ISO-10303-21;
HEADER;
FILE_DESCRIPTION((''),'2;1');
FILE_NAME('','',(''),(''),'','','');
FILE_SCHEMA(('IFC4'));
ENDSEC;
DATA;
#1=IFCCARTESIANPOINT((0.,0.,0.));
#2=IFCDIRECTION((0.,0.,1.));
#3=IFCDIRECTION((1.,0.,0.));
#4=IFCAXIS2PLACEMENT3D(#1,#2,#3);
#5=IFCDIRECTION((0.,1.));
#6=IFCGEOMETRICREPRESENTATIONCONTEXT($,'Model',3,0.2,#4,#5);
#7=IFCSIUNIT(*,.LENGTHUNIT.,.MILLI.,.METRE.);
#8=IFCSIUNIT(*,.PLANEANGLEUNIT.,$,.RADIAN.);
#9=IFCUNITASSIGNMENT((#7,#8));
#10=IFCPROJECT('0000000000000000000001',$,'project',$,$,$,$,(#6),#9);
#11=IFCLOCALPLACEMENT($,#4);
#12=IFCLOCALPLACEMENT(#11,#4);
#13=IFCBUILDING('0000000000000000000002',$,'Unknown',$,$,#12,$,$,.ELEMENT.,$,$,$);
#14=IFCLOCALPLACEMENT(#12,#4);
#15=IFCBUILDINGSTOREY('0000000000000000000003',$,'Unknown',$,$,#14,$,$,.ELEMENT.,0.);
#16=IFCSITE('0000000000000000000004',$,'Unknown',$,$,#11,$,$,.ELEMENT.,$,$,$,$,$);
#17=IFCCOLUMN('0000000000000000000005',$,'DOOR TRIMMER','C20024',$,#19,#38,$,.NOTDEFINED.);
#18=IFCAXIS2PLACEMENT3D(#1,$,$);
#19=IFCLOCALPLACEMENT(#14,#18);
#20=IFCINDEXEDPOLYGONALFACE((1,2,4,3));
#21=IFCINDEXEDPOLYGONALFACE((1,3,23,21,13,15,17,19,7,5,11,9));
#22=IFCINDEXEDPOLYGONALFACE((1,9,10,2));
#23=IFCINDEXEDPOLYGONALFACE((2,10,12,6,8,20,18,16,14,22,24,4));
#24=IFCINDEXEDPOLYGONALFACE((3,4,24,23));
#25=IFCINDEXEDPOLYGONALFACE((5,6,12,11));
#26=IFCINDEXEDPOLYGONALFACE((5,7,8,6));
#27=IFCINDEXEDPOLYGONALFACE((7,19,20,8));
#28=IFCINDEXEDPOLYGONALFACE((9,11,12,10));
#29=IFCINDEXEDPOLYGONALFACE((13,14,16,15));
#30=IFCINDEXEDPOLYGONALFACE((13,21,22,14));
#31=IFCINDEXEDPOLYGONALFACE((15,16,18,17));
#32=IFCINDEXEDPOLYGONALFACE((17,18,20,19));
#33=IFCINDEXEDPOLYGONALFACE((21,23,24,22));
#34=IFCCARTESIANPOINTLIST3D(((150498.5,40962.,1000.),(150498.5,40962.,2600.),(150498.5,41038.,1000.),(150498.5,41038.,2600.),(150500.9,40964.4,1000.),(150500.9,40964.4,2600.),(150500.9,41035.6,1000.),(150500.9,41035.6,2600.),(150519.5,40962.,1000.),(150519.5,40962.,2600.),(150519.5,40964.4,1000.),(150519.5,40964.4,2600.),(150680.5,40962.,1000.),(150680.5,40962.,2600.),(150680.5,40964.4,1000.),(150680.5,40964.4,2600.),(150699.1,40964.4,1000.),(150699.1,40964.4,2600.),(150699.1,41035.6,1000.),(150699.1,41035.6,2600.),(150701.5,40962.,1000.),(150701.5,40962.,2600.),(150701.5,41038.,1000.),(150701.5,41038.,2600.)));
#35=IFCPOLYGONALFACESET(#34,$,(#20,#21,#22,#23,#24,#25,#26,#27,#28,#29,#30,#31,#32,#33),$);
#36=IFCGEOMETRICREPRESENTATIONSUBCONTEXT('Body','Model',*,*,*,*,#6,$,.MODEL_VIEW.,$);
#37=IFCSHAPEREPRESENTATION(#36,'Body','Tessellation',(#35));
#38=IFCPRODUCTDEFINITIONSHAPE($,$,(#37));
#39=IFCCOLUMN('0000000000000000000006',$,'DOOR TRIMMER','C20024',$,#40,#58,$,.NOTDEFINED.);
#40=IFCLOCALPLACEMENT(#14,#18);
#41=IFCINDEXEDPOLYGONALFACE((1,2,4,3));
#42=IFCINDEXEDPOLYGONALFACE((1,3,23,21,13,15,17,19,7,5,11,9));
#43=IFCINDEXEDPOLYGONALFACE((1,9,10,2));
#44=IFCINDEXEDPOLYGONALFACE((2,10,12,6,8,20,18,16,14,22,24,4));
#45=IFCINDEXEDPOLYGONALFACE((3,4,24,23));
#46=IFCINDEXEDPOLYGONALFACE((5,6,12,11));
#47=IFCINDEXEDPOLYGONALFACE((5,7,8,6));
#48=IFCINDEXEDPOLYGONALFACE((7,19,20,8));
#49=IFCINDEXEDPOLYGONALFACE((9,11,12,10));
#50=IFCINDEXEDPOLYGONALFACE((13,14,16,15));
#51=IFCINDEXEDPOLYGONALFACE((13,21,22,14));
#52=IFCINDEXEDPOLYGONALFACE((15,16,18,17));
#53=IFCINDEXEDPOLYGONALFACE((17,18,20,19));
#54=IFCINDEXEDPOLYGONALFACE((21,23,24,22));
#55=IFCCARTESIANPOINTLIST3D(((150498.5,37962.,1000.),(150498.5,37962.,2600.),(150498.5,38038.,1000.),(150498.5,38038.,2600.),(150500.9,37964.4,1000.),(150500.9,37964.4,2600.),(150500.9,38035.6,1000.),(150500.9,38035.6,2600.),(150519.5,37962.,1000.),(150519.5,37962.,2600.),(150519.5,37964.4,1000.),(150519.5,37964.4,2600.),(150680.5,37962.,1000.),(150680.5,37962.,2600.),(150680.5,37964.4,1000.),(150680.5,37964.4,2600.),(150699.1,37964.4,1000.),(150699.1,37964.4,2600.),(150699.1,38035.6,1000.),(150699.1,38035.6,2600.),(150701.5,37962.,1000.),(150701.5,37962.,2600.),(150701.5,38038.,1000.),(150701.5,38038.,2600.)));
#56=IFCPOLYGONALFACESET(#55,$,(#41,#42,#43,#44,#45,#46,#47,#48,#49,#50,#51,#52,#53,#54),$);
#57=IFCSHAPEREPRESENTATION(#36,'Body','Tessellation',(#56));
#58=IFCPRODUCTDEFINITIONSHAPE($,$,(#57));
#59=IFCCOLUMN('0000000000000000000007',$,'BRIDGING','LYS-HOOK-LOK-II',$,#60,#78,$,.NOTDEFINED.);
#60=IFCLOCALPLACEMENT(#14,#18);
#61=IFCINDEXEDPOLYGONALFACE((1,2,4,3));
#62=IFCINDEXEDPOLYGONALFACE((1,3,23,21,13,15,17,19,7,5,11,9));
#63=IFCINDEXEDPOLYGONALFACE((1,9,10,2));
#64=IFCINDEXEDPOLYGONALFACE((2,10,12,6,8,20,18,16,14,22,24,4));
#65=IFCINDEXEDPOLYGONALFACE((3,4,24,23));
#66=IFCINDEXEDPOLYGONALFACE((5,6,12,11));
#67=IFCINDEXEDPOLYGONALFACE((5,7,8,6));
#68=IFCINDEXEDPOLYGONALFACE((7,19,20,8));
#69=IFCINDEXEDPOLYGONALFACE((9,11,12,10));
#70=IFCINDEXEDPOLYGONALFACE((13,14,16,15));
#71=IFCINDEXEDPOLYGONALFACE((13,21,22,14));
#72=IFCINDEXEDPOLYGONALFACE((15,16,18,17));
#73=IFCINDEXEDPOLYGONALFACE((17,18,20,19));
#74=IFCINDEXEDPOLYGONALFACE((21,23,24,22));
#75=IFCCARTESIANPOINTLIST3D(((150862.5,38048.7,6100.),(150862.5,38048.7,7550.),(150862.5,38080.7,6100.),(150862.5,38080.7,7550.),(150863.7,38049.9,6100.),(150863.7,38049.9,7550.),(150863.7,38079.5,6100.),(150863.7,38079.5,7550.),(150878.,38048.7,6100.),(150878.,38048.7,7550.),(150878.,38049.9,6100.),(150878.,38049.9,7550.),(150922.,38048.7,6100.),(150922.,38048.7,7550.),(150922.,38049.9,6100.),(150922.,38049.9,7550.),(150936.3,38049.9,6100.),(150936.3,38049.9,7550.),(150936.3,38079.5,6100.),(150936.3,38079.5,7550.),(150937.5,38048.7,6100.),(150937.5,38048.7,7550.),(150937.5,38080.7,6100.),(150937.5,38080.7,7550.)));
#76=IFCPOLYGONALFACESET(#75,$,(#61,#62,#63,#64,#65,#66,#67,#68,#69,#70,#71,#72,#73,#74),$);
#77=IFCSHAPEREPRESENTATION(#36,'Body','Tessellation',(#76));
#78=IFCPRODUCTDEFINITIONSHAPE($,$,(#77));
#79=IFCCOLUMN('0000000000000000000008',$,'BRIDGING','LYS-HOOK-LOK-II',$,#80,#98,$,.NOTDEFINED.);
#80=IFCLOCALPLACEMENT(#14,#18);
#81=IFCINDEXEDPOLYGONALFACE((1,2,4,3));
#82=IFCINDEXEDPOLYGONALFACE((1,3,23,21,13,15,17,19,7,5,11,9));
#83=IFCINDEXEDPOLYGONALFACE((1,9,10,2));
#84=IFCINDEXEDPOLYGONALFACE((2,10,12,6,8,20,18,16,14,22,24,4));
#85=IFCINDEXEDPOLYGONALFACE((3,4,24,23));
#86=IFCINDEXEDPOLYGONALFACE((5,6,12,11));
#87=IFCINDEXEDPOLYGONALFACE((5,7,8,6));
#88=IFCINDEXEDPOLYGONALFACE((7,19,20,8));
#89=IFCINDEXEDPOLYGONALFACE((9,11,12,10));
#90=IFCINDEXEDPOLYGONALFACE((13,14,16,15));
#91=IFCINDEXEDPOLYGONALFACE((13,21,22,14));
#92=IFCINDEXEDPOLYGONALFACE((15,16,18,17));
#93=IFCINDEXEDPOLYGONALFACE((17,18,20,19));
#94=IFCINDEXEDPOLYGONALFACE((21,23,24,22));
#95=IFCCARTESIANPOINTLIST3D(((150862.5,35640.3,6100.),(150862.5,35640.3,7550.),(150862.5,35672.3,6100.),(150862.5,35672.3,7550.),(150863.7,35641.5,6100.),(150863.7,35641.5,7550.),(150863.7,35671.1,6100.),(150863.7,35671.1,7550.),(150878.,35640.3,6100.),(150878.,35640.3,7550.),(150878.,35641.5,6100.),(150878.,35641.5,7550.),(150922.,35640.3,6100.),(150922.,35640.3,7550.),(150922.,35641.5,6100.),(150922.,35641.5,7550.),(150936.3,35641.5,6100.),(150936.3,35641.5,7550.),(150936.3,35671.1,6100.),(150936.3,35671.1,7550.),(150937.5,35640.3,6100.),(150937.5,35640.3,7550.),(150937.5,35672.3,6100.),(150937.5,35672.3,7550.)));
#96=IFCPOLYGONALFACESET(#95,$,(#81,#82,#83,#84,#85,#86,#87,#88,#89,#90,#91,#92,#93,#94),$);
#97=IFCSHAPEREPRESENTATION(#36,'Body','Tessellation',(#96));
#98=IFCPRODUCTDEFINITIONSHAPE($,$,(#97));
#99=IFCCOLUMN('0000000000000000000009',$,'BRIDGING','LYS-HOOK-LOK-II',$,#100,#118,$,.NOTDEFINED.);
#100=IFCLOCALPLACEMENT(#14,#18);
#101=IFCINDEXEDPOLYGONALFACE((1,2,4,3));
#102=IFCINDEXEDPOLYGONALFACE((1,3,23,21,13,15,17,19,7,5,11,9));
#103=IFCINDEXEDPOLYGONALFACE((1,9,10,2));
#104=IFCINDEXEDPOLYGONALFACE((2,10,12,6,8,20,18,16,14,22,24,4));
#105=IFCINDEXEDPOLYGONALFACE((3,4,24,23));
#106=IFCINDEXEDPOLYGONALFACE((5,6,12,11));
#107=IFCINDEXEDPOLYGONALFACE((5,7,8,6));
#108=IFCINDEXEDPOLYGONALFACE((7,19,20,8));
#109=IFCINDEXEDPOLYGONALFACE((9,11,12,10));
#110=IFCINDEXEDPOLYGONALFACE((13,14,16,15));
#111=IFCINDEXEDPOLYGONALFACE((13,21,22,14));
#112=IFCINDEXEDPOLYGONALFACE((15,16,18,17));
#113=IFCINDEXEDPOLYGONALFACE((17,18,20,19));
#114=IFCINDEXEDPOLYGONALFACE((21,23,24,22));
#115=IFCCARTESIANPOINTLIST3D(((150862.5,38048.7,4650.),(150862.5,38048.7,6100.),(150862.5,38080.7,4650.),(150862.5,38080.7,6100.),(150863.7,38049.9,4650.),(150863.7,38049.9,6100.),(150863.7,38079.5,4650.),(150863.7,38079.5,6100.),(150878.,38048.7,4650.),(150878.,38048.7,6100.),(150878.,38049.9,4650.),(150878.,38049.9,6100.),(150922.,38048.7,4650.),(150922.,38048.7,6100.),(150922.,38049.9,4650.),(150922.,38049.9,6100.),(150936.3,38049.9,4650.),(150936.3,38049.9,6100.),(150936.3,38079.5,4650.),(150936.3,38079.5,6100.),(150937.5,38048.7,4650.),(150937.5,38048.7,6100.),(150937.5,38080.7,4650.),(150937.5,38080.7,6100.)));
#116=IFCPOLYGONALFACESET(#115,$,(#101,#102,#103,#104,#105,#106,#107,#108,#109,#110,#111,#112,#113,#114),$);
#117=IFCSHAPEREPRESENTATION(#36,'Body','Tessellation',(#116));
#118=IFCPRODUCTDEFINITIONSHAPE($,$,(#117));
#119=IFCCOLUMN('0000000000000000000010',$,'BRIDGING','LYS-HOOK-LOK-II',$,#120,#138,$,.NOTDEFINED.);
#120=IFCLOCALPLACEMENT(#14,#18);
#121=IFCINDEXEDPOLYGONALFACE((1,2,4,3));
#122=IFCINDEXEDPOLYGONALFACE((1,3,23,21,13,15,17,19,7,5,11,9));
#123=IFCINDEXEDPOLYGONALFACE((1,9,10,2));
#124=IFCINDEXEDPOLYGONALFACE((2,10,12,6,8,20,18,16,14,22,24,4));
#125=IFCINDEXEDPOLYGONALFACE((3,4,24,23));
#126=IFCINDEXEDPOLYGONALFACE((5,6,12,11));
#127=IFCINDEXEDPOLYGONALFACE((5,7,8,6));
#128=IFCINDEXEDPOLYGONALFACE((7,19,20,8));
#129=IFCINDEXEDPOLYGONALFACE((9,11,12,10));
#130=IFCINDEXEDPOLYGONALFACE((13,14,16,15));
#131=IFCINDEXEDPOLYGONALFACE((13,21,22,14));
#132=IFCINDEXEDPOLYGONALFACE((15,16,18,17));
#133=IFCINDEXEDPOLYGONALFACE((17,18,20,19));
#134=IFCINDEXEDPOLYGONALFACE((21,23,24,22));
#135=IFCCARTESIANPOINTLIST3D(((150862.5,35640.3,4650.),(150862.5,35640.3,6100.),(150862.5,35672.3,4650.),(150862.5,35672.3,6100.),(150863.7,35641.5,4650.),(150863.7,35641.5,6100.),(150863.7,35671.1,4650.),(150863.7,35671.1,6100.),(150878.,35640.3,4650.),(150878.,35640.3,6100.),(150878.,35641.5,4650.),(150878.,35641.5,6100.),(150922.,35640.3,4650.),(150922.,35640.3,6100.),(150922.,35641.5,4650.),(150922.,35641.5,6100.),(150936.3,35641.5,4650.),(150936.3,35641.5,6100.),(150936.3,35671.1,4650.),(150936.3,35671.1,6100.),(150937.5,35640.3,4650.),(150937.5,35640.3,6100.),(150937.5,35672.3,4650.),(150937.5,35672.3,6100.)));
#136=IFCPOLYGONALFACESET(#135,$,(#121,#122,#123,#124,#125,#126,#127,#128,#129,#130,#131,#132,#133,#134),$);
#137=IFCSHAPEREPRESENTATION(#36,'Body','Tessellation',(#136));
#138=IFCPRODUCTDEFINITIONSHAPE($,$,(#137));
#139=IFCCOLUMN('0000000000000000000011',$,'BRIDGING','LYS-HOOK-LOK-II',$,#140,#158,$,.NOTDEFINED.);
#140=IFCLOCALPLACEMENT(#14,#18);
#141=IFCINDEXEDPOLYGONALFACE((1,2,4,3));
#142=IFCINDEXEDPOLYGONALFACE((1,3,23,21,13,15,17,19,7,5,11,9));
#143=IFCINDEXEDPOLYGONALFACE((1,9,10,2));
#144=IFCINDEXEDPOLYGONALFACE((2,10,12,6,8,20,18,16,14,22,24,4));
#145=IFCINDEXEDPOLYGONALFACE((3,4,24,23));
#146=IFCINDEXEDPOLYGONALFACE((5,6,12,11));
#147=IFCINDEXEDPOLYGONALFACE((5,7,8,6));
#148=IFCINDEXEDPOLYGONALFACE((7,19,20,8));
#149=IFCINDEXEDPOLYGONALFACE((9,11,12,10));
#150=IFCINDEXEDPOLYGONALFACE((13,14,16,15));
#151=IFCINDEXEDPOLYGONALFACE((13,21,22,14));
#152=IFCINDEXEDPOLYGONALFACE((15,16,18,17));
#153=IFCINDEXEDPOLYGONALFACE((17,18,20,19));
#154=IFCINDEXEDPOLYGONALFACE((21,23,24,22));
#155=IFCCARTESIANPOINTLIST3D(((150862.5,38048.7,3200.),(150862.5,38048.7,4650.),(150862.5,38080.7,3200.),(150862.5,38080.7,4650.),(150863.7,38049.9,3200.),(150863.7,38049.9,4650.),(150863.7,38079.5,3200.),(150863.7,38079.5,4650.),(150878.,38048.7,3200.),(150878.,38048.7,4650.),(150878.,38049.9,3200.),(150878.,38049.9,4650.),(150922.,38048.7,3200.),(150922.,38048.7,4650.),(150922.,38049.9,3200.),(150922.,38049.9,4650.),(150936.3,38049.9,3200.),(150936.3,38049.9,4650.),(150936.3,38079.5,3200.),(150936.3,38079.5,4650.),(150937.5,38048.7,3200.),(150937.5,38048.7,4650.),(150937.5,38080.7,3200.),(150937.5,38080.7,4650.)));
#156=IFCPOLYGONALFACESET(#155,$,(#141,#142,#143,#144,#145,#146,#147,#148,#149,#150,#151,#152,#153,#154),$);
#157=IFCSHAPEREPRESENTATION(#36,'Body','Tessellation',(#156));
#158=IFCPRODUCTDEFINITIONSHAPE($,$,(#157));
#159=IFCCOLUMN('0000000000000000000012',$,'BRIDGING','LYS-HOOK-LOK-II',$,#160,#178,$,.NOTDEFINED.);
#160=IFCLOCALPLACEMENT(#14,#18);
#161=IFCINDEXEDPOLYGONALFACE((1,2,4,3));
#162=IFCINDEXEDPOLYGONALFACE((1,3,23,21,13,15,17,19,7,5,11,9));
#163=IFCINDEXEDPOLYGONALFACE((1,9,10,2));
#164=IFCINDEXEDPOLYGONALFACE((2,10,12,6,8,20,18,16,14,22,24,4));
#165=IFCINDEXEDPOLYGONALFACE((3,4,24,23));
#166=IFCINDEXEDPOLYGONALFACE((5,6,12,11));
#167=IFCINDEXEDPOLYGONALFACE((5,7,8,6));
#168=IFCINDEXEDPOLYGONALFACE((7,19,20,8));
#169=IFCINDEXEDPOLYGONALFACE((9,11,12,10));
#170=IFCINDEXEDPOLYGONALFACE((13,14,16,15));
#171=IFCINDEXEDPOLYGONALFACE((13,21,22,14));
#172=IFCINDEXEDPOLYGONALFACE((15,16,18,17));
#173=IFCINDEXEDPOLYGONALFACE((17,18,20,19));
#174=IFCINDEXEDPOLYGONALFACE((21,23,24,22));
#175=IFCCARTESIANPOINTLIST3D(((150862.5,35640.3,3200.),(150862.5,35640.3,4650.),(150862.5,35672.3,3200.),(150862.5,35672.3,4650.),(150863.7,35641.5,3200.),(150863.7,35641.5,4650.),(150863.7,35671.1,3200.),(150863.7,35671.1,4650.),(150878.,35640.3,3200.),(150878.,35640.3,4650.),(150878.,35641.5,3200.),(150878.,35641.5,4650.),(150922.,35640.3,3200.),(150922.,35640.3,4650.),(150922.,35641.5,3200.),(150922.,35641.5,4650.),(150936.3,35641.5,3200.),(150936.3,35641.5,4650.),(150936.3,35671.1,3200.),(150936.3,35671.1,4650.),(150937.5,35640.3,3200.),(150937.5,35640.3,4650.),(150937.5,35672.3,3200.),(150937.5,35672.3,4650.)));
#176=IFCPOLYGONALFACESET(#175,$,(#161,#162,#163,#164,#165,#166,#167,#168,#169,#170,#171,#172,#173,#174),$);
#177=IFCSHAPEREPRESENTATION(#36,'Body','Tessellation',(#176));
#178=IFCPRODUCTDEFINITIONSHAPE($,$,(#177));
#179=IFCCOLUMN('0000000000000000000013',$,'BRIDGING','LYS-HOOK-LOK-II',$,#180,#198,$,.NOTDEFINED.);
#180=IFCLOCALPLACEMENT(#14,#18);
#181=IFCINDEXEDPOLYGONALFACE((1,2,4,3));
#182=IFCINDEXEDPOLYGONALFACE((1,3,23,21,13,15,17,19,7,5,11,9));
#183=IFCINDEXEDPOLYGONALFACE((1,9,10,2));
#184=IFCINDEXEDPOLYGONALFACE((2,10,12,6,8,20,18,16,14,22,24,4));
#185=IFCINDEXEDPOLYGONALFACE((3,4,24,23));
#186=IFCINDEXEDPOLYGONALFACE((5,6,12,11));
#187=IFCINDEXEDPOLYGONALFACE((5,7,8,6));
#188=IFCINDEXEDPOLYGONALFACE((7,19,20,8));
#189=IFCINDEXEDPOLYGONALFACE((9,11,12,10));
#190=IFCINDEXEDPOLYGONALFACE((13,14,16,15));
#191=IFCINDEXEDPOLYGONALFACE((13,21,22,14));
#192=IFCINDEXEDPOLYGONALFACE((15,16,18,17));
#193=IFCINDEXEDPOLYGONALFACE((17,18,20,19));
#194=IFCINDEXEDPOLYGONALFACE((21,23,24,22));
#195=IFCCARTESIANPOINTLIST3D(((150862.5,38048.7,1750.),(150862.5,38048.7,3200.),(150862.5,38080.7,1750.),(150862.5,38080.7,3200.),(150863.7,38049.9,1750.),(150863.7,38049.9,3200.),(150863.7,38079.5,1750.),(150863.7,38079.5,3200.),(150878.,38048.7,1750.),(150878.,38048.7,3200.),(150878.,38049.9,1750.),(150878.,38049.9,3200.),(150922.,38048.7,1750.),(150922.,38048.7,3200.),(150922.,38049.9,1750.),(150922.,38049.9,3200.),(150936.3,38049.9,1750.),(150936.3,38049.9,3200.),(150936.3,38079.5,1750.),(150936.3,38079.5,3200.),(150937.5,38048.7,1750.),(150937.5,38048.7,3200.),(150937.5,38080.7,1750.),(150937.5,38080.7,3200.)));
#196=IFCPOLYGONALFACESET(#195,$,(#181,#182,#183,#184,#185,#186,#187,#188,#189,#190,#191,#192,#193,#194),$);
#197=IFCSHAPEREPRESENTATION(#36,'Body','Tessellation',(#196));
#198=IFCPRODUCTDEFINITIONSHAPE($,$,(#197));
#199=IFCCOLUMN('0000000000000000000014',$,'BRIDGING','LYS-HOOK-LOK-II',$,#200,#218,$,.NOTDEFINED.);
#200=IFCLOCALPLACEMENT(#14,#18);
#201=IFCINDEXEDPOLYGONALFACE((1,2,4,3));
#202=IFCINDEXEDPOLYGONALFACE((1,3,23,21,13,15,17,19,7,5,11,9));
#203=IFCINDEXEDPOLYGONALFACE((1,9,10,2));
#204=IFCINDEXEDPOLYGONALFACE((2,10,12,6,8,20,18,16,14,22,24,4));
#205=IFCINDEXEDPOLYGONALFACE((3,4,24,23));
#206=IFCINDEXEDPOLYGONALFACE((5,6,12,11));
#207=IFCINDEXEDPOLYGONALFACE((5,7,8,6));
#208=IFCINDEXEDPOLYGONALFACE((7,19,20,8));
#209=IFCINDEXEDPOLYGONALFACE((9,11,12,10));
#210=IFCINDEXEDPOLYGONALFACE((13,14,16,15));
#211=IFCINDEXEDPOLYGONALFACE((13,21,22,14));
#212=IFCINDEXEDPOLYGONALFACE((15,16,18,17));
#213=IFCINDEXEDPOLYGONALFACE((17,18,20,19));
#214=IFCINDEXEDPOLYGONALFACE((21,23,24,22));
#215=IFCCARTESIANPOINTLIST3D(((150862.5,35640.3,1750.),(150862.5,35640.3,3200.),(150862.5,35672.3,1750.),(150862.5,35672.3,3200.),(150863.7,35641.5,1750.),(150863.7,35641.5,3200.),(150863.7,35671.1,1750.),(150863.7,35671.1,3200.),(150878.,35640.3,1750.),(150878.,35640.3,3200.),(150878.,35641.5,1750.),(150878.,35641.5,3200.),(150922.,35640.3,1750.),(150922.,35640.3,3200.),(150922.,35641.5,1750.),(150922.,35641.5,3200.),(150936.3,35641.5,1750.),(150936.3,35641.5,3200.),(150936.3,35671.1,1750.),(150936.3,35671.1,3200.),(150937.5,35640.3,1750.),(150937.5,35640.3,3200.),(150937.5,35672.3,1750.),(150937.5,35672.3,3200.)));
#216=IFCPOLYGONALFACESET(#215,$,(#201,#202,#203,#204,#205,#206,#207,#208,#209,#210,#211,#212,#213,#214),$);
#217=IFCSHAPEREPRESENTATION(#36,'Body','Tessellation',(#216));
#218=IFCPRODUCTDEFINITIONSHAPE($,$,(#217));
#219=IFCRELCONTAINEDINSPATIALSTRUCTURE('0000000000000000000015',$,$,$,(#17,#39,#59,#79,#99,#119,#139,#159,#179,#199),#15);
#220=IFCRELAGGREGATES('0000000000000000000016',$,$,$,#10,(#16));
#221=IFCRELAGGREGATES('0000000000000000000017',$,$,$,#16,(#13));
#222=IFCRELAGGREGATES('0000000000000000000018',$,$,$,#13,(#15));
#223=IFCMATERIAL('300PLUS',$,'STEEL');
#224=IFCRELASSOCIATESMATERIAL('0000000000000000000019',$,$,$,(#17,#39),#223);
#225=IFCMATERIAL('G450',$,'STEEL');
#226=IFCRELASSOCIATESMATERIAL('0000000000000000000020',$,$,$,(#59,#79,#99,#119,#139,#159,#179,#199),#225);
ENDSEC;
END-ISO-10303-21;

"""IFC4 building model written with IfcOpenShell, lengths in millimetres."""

from ifc_helpers import new_model, si_unit, direction, frame, origin_with_axes, place, context, subcontext, project, spatial, line, indexed_curve, outline, extrude, material, element, save


model = new_model("IFC4")

# Units and contexts
model_context = context("Model", 3, precision=0.2, world=origin_with_axes(), true_north=direction((0.0, 1.0)))
body_context = subcontext(model_context, "Body", "Model", "MODEL_VIEW")
ifc_project = project(units=[si_unit("LENGTHUNIT", "METRE", prefix="MILLI"), si_unit("PLANEANGLEUNIT", "RADIAN")], contexts=[model_context])

# Site, building, storey
site_placement = place(None, origin_with_axes())
site = spatial("IfcSite", under=ifc_project, at=site_placement, Name="Unknown", CompositionType="ELEMENT")
building_placement = place(site_placement, origin_with_axes())
building = spatial("IfcBuilding", under=site, at=building_placement, Name="Unknown", CompositionType="ELEMENT")
storey_placement = place(building_placement, origin_with_axes())
storey = spatial("IfcBuildingStorey", under=building, at=storey_placement, Name="Unknown", CompositionType="ELEMENT", Elevation=0.0)

# Columns
ifc_material_1 = material(Name="300PLUS", Category="STEEL")
for number, where, z_axis, x_axis, name in (
    (1, (150600.0, 41000.0, 1000.0), (0.0, -1.0, 0.0), (0.0, 0.0, 1.0), "DOOR TRIMMER"),
    (2, (150600.0, 38000.0, 1000.0), (0.0, -1.0, 0.0), (0.0, 0.0, 1.0), "DOOR TRIMMER"),
):
    element("IfcColumn", number, at=place(storey_placement, frame(where, z_axis=z_axis, x_axis=x_axis)), inside=storey, material=ifc_material_1, Name=name, Description="C20024", PredefinedType="NOTDEFINED", context=body_context, shape_type="SolidModel", body=[
        extrude(outline(indexed_curve([(38.0, -101.5), (38.0, -80.5), (35.6, -80.5), (35.6, -99.1), (-35.6, -99.1), (-35.6, 99.1), (35.6, 99.1), (35.6, 80.5), (38.0, 80.5), (38.0, 101.5), (-38.0, 101.5), (-38.0, -101.5)], segments=[line(1, 2, 3, 4, 5, 6, 7, 8, 9, 10, 11, 12, 1)])), frame((0.0, 0.0, 0.0), z_axis=(-1.0, 0.0, 0.0), x_axis=(0.0, 0.0, 1.0)), (0.0, 0.0, -1.0), 1600.0),
    ])
ifc_material_2 = material(Name="G450", Category="STEEL")
for number, where, z_axis, x_axis, name in (
    (3, (150900.0, 38064.7, 6100.0), (0.0, -1.0, 0.0), (0.0, 0.0, 1.0), "BRIDGING"),
    (4, (150900.0, 35656.3, 6100.0), (0.0, -1.0, 0.0), (0.0, 0.0, 1.0), "BRIDGING"),
    (5, (150900.0, 38064.7, 4650.0), (0.0, -1.0, 0.0), (0.0, 0.0, 1.0), "BRIDGING"),
    (6, (150900.0, 35656.3, 4650.0), (0.0, -1.0, 0.0), (0.0, 0.0, 1.0), "BRIDGING"),
    (7, (150900.0, 38064.7, 3200.0), (0.0, -1.0, 0.0), (0.0, 0.0, 1.0), "BRIDGING"),
    (8, (150900.0, 35656.3, 3200.0), (0.0, -1.0, 0.0), (0.0, 0.0, 1.0), "BRIDGING"),
    (9, (150900.0, 38064.7, 1750.0), (0.0, -1.0, 0.0), (0.0, 0.0, 1.0), "BRIDGING"),
    (10, (150900.0, 35656.3, 1750.0), (0.0, -1.0, 0.0), (0.0, 0.0, 1.0), "BRIDGING"),
):
    element("IfcColumn", number, at=place(storey_placement, frame(where, z_axis=z_axis, x_axis=x_axis)), inside=storey, material=ifc_material_2, Name=name, Description="LYS-HOOK-LOK-II", PredefinedType="NOTDEFINED", context=body_context, shape_type="SolidModel", body=[
        extrude(outline(indexed_curve([(16.0, -37.5), (16.0, -22.0), (14.8, -22.0), (14.8, -36.3), (-14.8, -36.3), (-14.8, 36.3), (14.8, 36.3), (14.8, 22.0), (16.0, 22.0), (16.0, 37.5), (-16.0, 37.5), (-16.0, -37.5)], segments=[line(1, 2, 3, 4, 5, 6, 7, 8, 9, 10, 11, 12, 1)])), frame((0.0, 0.0, 0.0), z_axis=(-1.0, 0.0, 0.0), x_axis=(0.0, 0.0, 1.0)), (0.0, 0.0, -1.0), 1450.0),
    ])

save(model, "model.ifc")
